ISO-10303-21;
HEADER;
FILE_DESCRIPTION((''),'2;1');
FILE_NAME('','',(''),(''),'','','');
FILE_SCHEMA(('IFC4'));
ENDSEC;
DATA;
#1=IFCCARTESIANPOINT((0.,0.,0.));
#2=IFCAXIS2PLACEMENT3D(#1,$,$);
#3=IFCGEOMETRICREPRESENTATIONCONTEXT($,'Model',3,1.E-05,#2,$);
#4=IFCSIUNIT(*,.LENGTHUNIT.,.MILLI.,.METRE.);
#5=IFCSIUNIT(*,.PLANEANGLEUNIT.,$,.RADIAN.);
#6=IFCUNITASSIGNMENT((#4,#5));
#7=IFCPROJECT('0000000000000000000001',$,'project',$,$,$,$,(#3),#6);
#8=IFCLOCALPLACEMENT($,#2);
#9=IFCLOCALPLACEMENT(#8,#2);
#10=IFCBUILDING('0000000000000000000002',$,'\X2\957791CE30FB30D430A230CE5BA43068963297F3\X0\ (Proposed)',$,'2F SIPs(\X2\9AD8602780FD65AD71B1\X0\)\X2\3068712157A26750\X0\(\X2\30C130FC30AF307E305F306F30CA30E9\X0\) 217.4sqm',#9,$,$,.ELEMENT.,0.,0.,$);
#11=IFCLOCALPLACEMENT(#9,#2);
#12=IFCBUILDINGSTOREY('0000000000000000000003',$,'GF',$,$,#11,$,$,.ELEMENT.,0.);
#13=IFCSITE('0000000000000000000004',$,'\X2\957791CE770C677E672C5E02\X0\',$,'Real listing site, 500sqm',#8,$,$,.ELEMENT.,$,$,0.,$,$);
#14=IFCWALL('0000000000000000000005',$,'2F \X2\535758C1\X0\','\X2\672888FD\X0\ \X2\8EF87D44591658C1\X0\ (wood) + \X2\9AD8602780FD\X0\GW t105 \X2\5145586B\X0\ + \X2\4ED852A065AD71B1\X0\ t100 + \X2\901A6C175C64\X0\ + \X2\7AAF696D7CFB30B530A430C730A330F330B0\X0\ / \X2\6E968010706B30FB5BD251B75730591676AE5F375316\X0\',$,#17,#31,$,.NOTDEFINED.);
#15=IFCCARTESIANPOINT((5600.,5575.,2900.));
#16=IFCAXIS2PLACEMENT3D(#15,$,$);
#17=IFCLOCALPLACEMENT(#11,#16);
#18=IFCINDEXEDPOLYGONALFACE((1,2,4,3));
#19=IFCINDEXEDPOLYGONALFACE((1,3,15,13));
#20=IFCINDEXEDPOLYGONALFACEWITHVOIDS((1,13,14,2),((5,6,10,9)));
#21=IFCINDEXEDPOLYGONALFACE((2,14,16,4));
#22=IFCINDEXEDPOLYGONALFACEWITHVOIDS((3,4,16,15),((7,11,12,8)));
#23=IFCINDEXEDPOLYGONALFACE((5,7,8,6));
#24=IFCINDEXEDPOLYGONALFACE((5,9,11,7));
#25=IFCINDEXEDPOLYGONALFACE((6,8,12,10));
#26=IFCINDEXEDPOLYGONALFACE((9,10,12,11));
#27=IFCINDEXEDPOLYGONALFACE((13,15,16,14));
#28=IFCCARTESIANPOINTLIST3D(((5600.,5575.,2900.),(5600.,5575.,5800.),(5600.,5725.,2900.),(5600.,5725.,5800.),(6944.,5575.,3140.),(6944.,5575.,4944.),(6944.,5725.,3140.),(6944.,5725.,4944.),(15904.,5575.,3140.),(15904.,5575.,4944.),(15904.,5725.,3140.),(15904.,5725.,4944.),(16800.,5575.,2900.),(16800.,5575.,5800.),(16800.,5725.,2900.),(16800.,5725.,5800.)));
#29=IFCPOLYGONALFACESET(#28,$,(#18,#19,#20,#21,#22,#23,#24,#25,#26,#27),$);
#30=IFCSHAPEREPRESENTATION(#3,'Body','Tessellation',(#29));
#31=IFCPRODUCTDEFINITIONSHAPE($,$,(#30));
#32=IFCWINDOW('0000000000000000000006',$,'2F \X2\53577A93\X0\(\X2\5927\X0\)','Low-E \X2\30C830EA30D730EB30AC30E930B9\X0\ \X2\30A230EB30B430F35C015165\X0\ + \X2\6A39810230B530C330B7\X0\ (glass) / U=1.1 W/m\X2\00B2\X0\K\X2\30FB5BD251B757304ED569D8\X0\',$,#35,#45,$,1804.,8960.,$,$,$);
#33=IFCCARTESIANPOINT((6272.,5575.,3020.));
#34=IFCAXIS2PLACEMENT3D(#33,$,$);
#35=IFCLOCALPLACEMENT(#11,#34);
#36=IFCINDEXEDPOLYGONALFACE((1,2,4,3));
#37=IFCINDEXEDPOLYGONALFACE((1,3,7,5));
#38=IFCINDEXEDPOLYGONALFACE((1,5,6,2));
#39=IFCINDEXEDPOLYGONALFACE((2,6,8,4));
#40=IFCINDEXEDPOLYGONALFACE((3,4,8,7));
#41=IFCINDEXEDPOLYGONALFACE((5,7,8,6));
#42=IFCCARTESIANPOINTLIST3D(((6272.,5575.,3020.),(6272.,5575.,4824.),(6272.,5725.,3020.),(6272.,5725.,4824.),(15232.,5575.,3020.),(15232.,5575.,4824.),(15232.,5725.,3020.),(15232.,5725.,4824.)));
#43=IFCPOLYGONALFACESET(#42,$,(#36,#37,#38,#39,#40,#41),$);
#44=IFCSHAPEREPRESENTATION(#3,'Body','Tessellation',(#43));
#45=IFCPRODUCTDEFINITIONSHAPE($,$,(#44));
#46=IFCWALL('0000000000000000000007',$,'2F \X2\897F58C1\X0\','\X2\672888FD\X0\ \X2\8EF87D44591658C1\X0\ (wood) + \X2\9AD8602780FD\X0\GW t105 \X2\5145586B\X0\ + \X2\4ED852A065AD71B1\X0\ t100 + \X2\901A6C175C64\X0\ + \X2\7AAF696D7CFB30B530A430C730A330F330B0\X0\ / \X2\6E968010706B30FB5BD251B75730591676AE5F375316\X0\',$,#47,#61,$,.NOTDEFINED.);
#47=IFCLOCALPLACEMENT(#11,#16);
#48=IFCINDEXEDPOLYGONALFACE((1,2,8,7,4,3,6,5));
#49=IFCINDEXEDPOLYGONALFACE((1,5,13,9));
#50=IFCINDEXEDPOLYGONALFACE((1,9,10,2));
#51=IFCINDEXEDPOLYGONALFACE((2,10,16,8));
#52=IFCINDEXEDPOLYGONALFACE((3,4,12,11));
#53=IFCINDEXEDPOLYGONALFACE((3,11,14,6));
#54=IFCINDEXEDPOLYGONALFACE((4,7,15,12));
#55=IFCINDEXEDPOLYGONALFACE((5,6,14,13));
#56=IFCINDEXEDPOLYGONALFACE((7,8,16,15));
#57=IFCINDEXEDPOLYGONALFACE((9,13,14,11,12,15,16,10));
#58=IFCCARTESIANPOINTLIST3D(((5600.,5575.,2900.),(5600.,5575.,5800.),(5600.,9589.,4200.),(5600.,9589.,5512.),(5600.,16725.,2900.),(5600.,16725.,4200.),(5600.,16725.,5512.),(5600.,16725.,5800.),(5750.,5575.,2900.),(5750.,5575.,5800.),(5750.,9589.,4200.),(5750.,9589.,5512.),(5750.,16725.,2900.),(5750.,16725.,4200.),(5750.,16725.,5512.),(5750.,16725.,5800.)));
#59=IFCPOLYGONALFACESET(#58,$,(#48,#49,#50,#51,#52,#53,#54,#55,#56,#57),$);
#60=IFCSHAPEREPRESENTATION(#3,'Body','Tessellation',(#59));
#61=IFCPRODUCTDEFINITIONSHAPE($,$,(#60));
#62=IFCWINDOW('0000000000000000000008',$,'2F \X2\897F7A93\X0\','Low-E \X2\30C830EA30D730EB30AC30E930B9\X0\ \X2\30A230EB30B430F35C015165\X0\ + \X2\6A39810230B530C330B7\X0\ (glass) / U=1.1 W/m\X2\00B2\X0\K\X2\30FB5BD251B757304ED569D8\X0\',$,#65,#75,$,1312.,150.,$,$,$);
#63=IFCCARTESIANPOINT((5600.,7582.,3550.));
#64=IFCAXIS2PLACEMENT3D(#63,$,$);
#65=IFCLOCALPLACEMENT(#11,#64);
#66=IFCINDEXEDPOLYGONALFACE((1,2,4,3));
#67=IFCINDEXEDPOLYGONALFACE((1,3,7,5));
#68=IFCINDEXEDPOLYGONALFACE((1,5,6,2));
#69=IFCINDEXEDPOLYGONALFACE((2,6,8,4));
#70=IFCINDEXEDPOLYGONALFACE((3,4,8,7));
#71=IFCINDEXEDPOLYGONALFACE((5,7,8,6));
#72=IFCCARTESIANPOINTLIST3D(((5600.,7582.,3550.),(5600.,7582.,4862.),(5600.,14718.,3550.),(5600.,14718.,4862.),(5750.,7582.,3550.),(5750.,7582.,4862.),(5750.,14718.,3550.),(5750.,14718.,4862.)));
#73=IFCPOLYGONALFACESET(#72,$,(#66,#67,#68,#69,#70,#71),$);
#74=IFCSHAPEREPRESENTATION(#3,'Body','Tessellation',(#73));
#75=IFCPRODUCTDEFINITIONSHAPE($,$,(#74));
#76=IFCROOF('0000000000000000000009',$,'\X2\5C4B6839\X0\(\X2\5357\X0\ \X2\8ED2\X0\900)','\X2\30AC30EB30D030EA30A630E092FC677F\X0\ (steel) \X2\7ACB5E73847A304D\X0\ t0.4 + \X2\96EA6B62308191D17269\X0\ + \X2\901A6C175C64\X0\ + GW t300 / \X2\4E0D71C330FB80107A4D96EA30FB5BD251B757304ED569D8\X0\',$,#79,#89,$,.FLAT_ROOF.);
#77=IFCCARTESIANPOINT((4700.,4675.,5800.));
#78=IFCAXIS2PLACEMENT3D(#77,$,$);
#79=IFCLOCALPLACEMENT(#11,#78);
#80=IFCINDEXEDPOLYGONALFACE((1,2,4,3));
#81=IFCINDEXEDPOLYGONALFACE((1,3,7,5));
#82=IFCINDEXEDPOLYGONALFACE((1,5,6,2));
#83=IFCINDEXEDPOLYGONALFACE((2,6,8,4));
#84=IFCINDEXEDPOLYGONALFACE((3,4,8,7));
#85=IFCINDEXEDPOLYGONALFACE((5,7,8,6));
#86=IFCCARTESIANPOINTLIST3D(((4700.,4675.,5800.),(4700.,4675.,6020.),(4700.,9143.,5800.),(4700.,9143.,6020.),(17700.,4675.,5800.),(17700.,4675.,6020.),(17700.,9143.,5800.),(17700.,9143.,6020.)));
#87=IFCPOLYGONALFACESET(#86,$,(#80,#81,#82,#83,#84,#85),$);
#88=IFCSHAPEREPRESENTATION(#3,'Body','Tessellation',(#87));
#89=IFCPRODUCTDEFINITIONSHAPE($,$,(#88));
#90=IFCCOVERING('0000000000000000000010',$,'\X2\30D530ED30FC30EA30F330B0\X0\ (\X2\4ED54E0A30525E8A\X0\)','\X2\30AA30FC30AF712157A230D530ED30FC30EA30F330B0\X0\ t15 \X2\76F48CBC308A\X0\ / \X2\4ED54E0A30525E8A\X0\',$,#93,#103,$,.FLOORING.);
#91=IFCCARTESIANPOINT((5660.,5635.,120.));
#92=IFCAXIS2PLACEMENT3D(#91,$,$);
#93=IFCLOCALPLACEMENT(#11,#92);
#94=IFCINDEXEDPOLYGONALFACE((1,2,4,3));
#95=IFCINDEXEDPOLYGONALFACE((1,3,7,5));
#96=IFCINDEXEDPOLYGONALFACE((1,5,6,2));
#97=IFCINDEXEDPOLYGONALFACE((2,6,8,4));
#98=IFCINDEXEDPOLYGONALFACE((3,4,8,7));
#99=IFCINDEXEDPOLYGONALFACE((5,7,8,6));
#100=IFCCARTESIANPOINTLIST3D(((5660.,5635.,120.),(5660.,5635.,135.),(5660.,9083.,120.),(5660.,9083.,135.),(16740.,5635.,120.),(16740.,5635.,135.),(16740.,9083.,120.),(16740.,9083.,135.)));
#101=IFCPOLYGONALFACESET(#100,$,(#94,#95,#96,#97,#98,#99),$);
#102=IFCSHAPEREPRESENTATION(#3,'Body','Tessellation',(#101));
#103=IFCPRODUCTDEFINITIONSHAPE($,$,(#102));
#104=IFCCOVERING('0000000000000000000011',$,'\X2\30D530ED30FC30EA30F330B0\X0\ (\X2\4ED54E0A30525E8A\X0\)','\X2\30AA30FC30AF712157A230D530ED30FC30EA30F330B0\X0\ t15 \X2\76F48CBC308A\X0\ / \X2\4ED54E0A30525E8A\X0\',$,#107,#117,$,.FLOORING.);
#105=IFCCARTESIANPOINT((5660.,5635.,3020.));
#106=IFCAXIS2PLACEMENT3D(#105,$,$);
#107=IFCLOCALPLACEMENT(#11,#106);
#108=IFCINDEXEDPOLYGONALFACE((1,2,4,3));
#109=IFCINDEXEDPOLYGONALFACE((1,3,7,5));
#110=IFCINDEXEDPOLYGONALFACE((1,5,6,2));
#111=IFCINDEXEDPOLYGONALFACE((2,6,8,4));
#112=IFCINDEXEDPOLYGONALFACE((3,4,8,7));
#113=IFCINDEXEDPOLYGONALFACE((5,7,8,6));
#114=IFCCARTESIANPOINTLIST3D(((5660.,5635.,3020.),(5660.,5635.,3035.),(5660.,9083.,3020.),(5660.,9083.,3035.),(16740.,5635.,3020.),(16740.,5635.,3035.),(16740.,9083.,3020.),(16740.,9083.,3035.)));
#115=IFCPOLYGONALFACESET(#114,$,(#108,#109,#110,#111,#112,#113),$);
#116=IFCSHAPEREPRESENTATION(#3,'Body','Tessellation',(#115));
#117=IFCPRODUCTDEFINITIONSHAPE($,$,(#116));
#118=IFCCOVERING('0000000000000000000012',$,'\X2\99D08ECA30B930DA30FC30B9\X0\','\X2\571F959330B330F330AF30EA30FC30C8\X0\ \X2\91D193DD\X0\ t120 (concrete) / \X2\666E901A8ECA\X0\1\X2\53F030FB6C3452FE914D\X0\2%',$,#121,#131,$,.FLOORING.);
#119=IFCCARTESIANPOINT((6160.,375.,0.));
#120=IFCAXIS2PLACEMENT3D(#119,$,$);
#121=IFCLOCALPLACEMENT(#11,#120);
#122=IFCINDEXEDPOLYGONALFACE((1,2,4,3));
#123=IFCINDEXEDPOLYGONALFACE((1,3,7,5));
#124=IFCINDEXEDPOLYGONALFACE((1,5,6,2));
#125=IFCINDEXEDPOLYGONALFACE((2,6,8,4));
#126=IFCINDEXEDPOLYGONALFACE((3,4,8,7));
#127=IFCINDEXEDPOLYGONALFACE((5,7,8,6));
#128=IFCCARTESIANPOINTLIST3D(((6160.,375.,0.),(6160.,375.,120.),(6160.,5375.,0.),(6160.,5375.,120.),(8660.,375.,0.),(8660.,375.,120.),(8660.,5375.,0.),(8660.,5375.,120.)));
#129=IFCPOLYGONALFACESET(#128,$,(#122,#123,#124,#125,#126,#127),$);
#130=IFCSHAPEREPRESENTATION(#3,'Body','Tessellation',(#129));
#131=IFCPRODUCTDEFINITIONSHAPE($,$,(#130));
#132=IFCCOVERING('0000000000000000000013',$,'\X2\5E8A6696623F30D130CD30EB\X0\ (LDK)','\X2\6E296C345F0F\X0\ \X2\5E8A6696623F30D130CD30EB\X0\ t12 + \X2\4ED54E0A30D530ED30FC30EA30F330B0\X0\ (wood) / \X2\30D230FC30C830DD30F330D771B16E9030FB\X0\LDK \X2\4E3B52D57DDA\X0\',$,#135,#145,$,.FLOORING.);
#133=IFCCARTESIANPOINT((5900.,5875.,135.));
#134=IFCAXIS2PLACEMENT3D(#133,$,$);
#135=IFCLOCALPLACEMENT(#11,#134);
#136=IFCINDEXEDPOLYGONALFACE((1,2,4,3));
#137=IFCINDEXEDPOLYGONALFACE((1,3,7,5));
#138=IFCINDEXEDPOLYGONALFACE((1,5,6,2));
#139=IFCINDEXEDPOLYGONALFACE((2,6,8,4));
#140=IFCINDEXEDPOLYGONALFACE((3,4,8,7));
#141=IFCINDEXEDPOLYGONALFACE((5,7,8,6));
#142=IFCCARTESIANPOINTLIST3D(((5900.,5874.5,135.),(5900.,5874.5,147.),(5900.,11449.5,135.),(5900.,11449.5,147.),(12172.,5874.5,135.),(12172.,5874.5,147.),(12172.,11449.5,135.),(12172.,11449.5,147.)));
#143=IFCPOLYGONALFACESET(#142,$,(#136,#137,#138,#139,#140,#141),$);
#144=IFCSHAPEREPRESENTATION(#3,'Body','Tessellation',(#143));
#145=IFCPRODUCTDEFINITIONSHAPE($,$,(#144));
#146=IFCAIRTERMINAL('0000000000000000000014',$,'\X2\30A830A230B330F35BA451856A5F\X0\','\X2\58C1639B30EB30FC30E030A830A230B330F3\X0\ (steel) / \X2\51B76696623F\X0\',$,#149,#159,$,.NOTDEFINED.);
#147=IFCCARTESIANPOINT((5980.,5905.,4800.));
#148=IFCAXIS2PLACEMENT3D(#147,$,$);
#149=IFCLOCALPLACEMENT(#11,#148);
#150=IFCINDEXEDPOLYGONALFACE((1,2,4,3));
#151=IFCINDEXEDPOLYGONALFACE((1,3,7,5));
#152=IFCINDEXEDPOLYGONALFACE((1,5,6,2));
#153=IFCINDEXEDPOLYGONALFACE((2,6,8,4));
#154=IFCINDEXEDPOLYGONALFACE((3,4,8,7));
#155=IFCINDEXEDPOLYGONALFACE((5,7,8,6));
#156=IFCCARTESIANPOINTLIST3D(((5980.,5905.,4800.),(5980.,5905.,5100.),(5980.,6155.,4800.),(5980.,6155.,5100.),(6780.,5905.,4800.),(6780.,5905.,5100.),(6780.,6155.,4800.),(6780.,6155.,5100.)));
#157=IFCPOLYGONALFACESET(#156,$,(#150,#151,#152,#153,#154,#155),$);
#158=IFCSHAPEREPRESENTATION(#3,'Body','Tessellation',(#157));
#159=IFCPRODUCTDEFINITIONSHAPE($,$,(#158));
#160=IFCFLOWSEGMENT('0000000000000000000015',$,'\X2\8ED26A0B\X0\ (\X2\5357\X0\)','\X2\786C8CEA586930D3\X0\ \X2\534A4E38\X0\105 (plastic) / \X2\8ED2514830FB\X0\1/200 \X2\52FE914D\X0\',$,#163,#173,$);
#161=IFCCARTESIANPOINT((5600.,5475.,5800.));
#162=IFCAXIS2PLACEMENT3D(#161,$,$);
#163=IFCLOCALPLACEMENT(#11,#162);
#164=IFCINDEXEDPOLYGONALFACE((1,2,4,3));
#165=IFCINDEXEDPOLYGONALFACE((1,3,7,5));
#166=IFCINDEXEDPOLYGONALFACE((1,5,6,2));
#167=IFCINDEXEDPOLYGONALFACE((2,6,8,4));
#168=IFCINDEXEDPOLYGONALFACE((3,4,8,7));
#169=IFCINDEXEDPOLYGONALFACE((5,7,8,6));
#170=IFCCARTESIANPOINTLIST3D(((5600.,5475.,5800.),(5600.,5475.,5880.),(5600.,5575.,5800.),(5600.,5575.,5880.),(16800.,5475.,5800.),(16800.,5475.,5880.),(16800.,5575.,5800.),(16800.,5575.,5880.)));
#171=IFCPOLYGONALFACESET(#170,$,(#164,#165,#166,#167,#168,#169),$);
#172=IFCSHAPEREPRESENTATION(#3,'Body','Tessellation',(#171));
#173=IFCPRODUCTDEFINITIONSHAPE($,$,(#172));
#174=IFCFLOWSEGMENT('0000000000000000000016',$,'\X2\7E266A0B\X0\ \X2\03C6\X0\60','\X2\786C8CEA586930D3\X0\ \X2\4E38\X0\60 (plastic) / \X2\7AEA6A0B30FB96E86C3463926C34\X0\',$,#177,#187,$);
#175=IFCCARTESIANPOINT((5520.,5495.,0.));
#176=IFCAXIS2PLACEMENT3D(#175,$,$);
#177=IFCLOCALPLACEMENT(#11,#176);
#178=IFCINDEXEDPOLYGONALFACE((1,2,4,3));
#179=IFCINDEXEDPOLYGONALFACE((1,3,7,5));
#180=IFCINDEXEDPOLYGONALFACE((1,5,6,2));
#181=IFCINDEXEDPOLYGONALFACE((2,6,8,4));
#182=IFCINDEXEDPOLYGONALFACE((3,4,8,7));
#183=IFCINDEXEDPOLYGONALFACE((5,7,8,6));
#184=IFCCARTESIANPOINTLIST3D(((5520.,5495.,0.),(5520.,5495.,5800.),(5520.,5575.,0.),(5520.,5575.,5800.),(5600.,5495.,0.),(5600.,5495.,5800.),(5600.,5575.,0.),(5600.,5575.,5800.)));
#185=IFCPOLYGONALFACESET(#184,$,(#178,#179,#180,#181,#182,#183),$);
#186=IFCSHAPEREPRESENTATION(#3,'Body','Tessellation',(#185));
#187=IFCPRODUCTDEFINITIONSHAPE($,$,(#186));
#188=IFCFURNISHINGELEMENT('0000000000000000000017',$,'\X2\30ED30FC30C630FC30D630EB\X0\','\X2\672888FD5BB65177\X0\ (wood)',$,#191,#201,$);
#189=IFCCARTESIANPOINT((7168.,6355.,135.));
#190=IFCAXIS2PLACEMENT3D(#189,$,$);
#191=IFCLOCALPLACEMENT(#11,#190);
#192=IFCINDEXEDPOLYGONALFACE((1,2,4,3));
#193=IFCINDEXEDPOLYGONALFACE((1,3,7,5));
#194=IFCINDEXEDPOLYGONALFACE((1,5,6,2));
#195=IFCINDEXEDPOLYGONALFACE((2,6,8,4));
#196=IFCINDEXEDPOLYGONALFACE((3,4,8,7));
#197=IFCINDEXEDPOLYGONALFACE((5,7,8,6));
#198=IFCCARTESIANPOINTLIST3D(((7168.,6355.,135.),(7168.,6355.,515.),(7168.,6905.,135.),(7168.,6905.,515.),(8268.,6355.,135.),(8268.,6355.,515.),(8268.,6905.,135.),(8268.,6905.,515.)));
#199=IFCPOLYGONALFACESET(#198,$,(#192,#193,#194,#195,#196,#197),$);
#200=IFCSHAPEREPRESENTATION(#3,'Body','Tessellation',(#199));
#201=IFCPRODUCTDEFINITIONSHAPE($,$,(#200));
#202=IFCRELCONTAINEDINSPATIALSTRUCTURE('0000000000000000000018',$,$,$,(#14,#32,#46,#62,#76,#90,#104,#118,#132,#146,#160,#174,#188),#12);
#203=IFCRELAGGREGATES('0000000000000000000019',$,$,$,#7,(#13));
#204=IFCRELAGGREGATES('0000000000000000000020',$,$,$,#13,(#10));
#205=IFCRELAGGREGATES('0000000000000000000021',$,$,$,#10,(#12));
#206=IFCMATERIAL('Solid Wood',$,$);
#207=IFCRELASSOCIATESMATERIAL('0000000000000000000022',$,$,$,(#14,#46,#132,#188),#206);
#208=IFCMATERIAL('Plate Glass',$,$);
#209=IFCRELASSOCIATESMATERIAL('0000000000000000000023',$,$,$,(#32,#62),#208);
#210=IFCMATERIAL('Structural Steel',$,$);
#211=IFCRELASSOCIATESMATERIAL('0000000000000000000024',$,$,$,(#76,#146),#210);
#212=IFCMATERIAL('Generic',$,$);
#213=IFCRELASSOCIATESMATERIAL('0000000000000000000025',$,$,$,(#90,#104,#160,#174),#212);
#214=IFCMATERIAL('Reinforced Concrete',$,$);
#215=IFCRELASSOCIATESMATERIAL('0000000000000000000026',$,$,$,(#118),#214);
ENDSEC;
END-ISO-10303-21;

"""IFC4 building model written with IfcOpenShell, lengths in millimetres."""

from ifc_helpers import new_model, si_unit, frame, frame_2d, origin, place, context, project, spatial, rectangle, extrude, material, element, fill, save


model = new_model("IFC4")

# Units and contexts
model_context = context("Model", 3, precision=1e-05, world=origin())
ifc_project = project(units=[si_unit("LENGTHUNIT", "METRE", prefix="MILLI"), si_unit("PLANEANGLEUNIT", "RADIAN")], contexts=[model_context])

# Site, building, storey
site_placement = place(None, origin())
site = spatial("IfcSite", under=ifc_project, at=site_placement, Name="長野県松本市", ObjectType="Real listing site, 500sqm", CompositionType="ELEMENT", RefElevation=0.0)
building_placement = place(site_placement, origin())
building = spatial("IfcBuilding", under=site, at=building_placement, Name="長野・ピアノ室と防音 (Proposed)", ObjectType="2F SIPs(高性能断熱)と無垢材(チークまたはナラ) 217.4sqm", CompositionType="ELEMENT", ElevationOfRefHeight=0.0, ElevationOfTerrain=0.0)
storey_placement = place(building_placement, origin())
storey = spatial("IfcBuildingStorey", under=building, at=storey_placement, Name="GF", CompositionType="ELEMENT", Elevation=0.0)

# Shared definitions
ifc_material_1 = material(Name="Solid Wood")

# Shared definitions
ifc_material_2 = material(Name="Reinforced Concrete")

# Shared definitions
ifc_material_3 = material(Name="Plate Glass")

# Walls, openings, windows
wall_1_placement = place(storey_placement, frame((5600.0, 5575.0, 2900.0)))
wall_1 = element("IfcWall", 1, at=wall_1_placement, inside=storey, material=ifc_material_1, Name="2F 南壁", Description="木製 軸組外壁 (wood) + 高性能GW t105 充填 + 付加断熱 t100 + 通気層 + 窯業系サイディング / 準耐火・寒冷地外皮強化", PredefinedType="NOTDEFINED", context=model_context, shape_type="SweptSolid", body=[
    extrude(rectangle(XDim=11200.0, YDim=150.0, at=frame_2d((5600.0, 75.0))), frame((5600.0, 5575.0, 2900.0)), (0.0, 0.0, 1.0), 2900.0),
])
opening_1_placement = place(storey_placement, frame((6272.0, 5575.0, 3020.0)))
opening_1 = element("IfcOpeningElement", 2, at=opening_1_placement, cuts=wall_1, PredefinedType="NOTDEFINED", context=model_context, shape_type="SweptSolid", body=[
    extrude(rectangle(XDim=8960.0, YDim=150.0, at=frame_2d((4480.0, 75.0))), frame((6272.0, 5575.0, 3020.0)), (0.0, 0.0, 1.0), 1804.0),
])
window_1_placement = place(storey_placement, frame((6272.0, 5575.0, 3020.0)))
window_1 = element("IfcWindow", 3, at=window_1_placement, inside=storey, material=ifc_material_3, Name="2F 南窓(大)", Description="Low-E トリプルガラス アルゴン封入 + 樹脂サッシ (glass) / U=1.1 W/m²K・寒冷地仕様", OverallHeight=1804.0, OverallWidth=8960.0, context=model_context, shape_type="SweptSolid", body=[
    extrude(rectangle(XDim=8960.0, YDim=150.0, at=frame_2d((4480.0, 75.0))), frame((6272.0, 5575.0, 3020.0)), (0.0, 0.0, 1.0), 1804.0),
])
fill(opening_1, window_1)
wall_2_placement = place(storey_placement, frame((5600.0, 5575.0, 2900.0)))
wall_2 = element("IfcWall", 4, at=wall_2_placement, inside=storey, material=ifc_material_1, Name="2F 西壁", Description="木製 軸組外壁 (wood) + 高性能GW t105 充填 + 付加断熱 t100 + 通気層 + 窯業系サイディング / 準耐火・寒冷地外皮強化", PredefinedType="NOTDEFINED", context=model_context, shape_type="SweptSolid", body=[
    extrude(rectangle(XDim=150.0, YDim=11150.0, at=frame_2d((75.0, 5575.0))), frame((5600.0, 5575.0, 2900.0)), (0.0, 0.0, 1.0), 2900.0),
])
opening_2_placement = place(storey_placement, frame((5600.0, 7582.0, 3550.0)))
opening_2 = element("IfcOpeningElement", 5, at=opening_2_placement, cuts=wall_2, PredefinedType="NOTDEFINED", context=model_context, shape_type="SweptSolid", body=[
    extrude(rectangle(XDim=150.0, YDim=7136.0, at=frame_2d((75.0, 3568.0))), frame((5600.0, 7582.0, 3550.0)), (0.0, 0.0, 1.0), 1312.0),
])
window_2_placement = place(storey_placement, frame((5600.0, 7582.0, 3550.0)))
window_2 = element("IfcWindow", 6, at=window_2_placement, inside=storey, material=ifc_material_3, Name="2F 西窓", Description="Low-E トリプルガラス アルゴン封入 + 樹脂サッシ (glass) / U=1.1 W/m²K・寒冷地仕様", OverallHeight=1312.0, OverallWidth=150.0, context=model_context, shape_type="SweptSolid", body=[
    extrude(rectangle(XDim=150.0, YDim=7136.0, at=frame_2d((75.0, 3568.0))), frame((5600.0, 7582.0, 3550.0)), (0.0, 0.0, 1.0), 1312.0),
])
fill(opening_2, window_2)

# Roof
ifc_material_4 = material(Name="Structural Steel")
for number, where, name in (
    (7, (4700.0, 4675.0, 5800.0), "屋根(南 軒900)"),
):
    element("IfcRoof", number, at=place(storey_placement, frame(where)), inside=storey, material=ifc_material_4, Name=name, Description="ガルバリウム鋼板 (steel) 立平葺き t0.4 + 雪止め金物 + 通気層 + GW t300 / 不燃・耐積雪・寒冷地仕様", PredefinedType="FLAT_ROOF", context=model_context, shape_type="SweptSolid", body=[
        extrude(rectangle(XDim=13000.0, YDim=4468.0, at=frame_2d((6500.0, 2234.0))), frame((4700.0, 4675.0, 5800.0)), (0.0, 0.0, 1.0), 220.0),
    ])

# Coverings
ifc_material_5 = material(Name="Generic")
covering_1_placement = place(storey_placement, frame((5660.0, 5635.0, 120.0)))
element("IfcCovering", 8, at=covering_1_placement, inside=storey, material=ifc_material_5, Name="フローリング (仕上げ床)", Description="オーク無垢フローリング t15 直貼り / 仕上げ床", PredefinedType="FLOORING", context=model_context, shape_type="SweptSolid", body=[
    extrude(rectangle(XDim=11080.0, YDim=3448.0, at=frame_2d((5540.0, 1724.0))), frame((5660.0, 5635.0, 120.0)), (0.0, 0.0, 1.0), 15.0),
])
covering_2_placement = place(storey_placement, frame((5660.0, 5635.0, 3020.0)))
element("IfcCovering", 9, at=covering_2_placement, inside=storey, material=ifc_material_5, Name="フローリング (仕上げ床)", Description="オーク無垢フローリング t15 直貼り / 仕上げ床", PredefinedType="FLOORING", context=model_context, shape_type="SweptSolid", body=[
    extrude(rectangle(XDim=11080.0, YDim=3448.0, at=frame_2d((5540.0, 1724.0))), frame((5660.0, 5635.0, 3020.0)), (0.0, 0.0, 1.0), 15.0),
])
covering_3_placement = place(storey_placement, frame((6160.0, 375.0, 0.0)))
element("IfcCovering", 10, at=covering_3_placement, inside=storey, material=ifc_material_2, Name="駐車スペース", Description="土間コンクリート 金鏝 t120 (concrete) / 普通車1台・水勾配2%", PredefinedType="FLOORING", context=model_context, shape_type="SweptSolid", body=[
    extrude(rectangle(XDim=2500.0, YDim=5000.0, at=frame_2d((1250.0, 2500.0))), frame((6160.0, 375.0, 0.0)), (0.0, 0.0, 1.0), 120.0),
])
covering_4_placement = place(storey_placement, frame((5900.0, 5875.0, 135.0)))
element("IfcCovering", 11, at=covering_4_placement, inside=storey, material=ifc_material_1, Name="床暖房パネル (LDK)", Description="温水式 床暖房パネル t12 + 仕上フローリング (wood) / ヒートポンプ熱源・LDK 主動線", PredefinedType="FLOORING", context=model_context, shape_type="SweptSolid", body=[
    extrude(rectangle(XDim=6272.0, YDim=5575.0, at=frame_2d((3136.0, 2787.0))), frame((5900.0, 5875.0, 135.0)), (0.0, 0.0, 1.0), 12.0),
])

# Air terminal
air_terminal_placement = place(storey_placement, frame((5980.0, 5905.0, 4800.0)))
element("IfcAirTerminal", 12, at=air_terminal_placement, inside=storey, material=ifc_material_4, Name="エアコン室内機", Description="壁掛ルームエアコン (steel) / 冷暖房", PredefinedType="NOTDEFINED", context=model_context, shape_type="SweptSolid", body=[
    extrude(rectangle(XDim=800.0, YDim=250.0, at=frame_2d((400.0, 125.0))), frame((5980.0, 5905.0, 4800.0)), (0.0, 0.0, 1.0), 300.0),
])

# Flow segments
flow_segment_1_placement = place(storey_placement, frame((5600.0, 5475.0, 5800.0)))
element("IfcFlowSegment", 13, at=flow_segment_1_placement, inside=storey, material=ifc_material_5, Name="軒樋 (南)", Description="硬質塩ビ 半丸105 (plastic) / 軒先・1/200 勾配", context=model_context, shape_type="SweptSolid", body=[
    extrude(rectangle(XDim=11200.0, YDim=100.0, at=frame_2d((5600.0, 50.0))), frame((5600.0, 5475.0, 5800.0)), (0.0, 0.0, 1.0), 80.0),
])
flow_segment_2_placement = place(storey_placement, frame((5520.0, 5495.0, 0.0)))
element("IfcFlowSegment", 14, at=flow_segment_2_placement, inside=storey, material=ifc_material_5, Name="縦樋 φ60", Description="硬質塩ビ 丸60 (plastic) / 竪樋・雨水排水", context=model_context, shape_type="SweptSolid", body=[
    extrude(rectangle(XDim=80.0, YDim=80.0, at=frame_2d((40.0, 40.0))), frame((5520.0, 5495.0, 0.0)), (0.0, 0.0, 1.0), 5800.0),
])

# Furnishing element
furnishing_1_placement = place(storey_placement, frame((7168.0, 6355.0, 135.0)))
element("IfcFurnishingElement", 15, at=furnishing_1_placement, inside=storey, material=ifc_material_1, Name="ローテーブル", Description="木製家具 (wood)", context=model_context, shape_type="SweptSolid", body=[
    extrude(rectangle(XDim=1100.0, YDim=550.0, at=frame_2d((550.0, 275.0))), frame((7168.0, 6355.0, 135.0)), (0.0, 0.0, 1.0), 380.0),
])

save(model, "model.ifc")
